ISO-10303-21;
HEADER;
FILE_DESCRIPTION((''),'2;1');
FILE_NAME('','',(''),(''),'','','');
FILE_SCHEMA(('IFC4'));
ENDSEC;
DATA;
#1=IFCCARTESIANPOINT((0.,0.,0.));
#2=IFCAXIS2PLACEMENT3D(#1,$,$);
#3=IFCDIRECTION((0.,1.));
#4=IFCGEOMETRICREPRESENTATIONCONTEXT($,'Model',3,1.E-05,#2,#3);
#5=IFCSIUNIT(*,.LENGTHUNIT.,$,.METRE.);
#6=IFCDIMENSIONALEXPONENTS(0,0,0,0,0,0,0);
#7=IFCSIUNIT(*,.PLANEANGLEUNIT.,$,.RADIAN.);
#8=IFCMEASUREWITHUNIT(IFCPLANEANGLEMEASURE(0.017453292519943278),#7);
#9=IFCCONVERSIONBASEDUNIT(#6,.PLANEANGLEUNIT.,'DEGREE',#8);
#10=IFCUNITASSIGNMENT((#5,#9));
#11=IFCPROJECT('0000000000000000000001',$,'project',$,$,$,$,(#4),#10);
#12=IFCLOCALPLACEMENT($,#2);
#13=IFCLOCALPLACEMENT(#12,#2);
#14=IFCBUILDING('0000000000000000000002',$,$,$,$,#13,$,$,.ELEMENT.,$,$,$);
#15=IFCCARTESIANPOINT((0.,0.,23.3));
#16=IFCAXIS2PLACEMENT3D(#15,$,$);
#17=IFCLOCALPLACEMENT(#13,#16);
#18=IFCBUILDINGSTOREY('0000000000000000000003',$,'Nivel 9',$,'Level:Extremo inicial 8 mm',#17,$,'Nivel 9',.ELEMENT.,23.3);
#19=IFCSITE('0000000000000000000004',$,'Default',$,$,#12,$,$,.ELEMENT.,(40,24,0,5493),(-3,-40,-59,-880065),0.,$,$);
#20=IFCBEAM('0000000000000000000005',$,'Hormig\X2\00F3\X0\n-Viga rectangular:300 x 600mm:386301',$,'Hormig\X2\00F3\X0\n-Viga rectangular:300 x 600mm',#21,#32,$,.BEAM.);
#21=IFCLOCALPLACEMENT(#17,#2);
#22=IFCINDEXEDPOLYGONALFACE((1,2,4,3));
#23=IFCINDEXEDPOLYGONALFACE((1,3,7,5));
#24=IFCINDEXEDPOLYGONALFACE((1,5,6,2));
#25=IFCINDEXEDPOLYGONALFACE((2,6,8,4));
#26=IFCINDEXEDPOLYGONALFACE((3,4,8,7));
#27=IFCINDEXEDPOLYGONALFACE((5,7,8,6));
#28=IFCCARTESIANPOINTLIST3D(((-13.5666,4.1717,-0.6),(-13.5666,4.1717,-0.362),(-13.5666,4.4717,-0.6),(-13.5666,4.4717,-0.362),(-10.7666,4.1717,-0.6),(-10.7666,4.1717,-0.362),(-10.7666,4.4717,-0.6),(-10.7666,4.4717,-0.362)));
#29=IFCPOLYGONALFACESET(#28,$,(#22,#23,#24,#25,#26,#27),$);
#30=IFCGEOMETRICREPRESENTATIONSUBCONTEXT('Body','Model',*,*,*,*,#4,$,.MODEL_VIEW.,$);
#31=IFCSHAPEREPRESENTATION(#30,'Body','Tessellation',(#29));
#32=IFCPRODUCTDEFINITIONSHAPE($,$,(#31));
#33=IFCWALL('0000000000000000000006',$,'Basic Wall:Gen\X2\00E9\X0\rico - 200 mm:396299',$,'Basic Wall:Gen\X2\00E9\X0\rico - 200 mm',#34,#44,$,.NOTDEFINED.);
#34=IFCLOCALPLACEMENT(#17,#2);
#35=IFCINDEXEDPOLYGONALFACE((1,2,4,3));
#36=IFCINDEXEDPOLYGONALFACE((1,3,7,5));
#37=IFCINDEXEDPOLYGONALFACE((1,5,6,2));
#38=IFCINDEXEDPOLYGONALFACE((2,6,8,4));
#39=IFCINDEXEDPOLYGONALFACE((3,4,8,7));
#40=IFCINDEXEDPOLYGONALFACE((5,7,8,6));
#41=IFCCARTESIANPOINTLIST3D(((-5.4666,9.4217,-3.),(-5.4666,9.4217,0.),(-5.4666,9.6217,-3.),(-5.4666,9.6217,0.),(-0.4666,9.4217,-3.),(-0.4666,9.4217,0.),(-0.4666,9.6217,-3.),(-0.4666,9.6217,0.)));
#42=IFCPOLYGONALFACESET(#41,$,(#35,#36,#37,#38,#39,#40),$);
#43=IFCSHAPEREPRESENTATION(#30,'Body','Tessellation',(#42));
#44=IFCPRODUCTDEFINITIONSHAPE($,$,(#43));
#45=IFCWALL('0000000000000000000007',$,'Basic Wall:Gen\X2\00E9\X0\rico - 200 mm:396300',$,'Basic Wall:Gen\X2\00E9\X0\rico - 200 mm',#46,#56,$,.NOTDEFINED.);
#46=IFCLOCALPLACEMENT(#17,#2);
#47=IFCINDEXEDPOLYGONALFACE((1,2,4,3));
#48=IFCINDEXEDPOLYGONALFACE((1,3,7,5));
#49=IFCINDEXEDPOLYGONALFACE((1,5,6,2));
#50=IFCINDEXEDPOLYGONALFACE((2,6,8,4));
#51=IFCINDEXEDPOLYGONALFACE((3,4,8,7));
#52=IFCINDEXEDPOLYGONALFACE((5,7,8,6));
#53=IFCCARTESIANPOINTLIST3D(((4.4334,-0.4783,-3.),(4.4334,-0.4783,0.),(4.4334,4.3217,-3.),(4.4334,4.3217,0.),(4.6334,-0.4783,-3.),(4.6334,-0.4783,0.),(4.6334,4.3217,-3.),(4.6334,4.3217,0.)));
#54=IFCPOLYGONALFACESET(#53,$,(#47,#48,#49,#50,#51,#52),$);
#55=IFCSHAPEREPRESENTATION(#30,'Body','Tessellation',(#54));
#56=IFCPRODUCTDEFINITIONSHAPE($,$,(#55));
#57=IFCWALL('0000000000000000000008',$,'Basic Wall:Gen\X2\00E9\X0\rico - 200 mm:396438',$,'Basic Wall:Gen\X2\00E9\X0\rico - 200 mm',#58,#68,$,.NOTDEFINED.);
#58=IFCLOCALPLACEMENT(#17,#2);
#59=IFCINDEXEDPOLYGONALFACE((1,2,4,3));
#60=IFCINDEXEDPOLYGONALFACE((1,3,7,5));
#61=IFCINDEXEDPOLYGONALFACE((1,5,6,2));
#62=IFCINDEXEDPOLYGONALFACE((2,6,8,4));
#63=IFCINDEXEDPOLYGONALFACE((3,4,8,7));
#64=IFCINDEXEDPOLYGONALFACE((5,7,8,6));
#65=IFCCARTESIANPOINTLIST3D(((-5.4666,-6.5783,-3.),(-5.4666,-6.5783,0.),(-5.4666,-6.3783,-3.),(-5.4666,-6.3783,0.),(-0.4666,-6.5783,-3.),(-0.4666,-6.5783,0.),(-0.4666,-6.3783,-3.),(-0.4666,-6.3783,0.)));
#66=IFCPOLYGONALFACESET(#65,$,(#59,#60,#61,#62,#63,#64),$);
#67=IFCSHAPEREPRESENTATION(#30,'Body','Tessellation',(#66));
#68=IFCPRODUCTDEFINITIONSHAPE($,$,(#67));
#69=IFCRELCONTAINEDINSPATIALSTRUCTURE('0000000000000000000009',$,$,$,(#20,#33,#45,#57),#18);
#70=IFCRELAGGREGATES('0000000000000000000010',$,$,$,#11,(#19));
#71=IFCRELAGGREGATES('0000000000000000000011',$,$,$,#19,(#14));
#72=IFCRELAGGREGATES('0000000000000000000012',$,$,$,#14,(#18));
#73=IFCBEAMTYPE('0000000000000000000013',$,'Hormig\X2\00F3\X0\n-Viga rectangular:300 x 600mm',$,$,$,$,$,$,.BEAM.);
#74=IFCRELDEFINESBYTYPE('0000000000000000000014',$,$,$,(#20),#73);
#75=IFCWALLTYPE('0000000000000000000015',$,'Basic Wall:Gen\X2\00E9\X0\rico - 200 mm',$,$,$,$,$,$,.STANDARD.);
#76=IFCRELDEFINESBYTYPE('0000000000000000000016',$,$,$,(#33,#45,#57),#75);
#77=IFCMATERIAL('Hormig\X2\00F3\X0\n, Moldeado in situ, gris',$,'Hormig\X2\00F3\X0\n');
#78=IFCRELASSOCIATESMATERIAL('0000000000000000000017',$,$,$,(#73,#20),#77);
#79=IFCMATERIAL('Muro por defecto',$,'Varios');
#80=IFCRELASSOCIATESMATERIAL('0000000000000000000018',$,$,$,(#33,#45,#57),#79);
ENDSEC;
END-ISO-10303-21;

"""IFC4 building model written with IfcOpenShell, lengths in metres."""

from ifc_helpers import new_model, entity, si_unit, converted_unit, direction, frame, origin, place, context, subcontext, project, spatial, indexed_curve, outline, extrude, source, transform, mapped, material, type_object, type_shapes, element, save


model = new_model("IFC4")

# Units and contexts
model_context = context("Model", 3, precision=1e-05, world=origin(), true_north=direction((0.0, 1.0)))
body_context = subcontext(model_context, "Body", "Model", "MODEL_VIEW")
ifc_project = project(units=[si_unit("LENGTHUNIT", "METRE"), converted_unit("PLANEANGLEUNIT", "DEGREE", entity("IfcPlaneAngleMeasure", 0.017453292519943278), si_unit("PLANEANGLEUNIT", "RADIAN"), dimensions=[0, 0, 0, 0, 0, 0, 0])], contexts=[model_context])

# Site, building, storey
site_placement = place(None, origin())
site = spatial("IfcSite", under=ifc_project, at=site_placement, Name="Default", CompositionType="ELEMENT", RefLatitude=(40, 24, 0, 5493), RefLongitude=(-3, -40, -59, -880065), RefElevation=0.0)
building_placement = place(site_placement, origin())
building = spatial("IfcBuilding", under=site, at=building_placement, CompositionType="ELEMENT")
storey_placement = place(building_placement, frame((0.0, 0.0, 23.3)))
storey = spatial("IfcBuildingStorey", under=building, at=storey_placement, Name="Nivel 9", ObjectType="Level:Extremo inicial 8 mm", LongName="Nivel 9", CompositionType="ELEMENT", Elevation=23.3)

# Shared definitions
ifc_material_1 = material(Name="Hormigón, Moldeado in situ, gris", Category="Hormigón")

# Beam
beam_type_1 = type_object("IfcBeamType", Name="Hormigón-Viga rectangular:300 x 600mm", PredefinedType="BEAM", material=ifc_material_1)
shared_shape_1 = source(origin(), body_context, "Body", "SweptSolid", [
    extrude(outline(indexed_curve([(-0.119, -0.15), (0.119, -0.15), (0.119, 0.15), (-0.119, 0.15), (-0.119, -0.15)], self_intersect=False)), frame((-10.7666, 4.3217, 22.819), z_axis=(-1.0, 0.0, 0.0), x_axis=(0.0, 0.0, -1.0)), (0.0, 0.0, 1.0), 2.8),
])
type_shapes(beam_type_1, [shared_shape_1])
beam_1_placement = place(storey_placement, frame((0.0, 0.0, -23.3)))
element("IfcBeam", 1, at=beam_1_placement, inside=storey, type_object=beam_type_1, material=ifc_material_1, Name="Hormigón-Viga rectangular:300 x 600mm:386301", ObjectType="Hormigón-Viga rectangular:300 x 600mm", PredefinedType="BEAM", context=body_context, shape_type="MappedRepresentation", body=[
    mapped(shared_shape_1, transform((0.0, 0.0, 0.0), scale=1.0)),
])

# Walls
ifc_material_2 = material(Name="Muro por defecto", Category="Varios")
wall_type = type_object("IfcWallType", Name="Basic Wall:Genérico - 200 mm", PredefinedType="STANDARD")
wall_1_placement = place(storey_placement, frame((-5.4666, 9.5217, -3.0)))
element("IfcWall", 2, at=wall_1_placement, inside=storey, type_object=wall_type, material=ifc_material_2, Name="Basic Wall:Genérico - 200 mm:396299", ObjectType="Basic Wall:Genérico - 200 mm", PredefinedType="NOTDEFINED", context=body_context, shape_type="SweptSolid", body=[
    extrude(outline(indexed_curve([(5.0, 0.1), (0.0, 0.1), (0.0, -0.1), (5.0, -0.1), (5.0, 0.1)], self_intersect=False)), origin(), (0.0, 0.0, 1.0), 3.0),
])
wall_2_placement = place(storey_placement, frame((4.5334, 4.3217, -3.0), z_axis=(0.0, 0.0, 1.0), x_axis=(0.0, -1.0, 0.0)))
element("IfcWall", 3, at=wall_2_placement, inside=storey, type_object=wall_type, material=ifc_material_2, Name="Basic Wall:Genérico - 200 mm:396300", ObjectType="Basic Wall:Genérico - 200 mm", PredefinedType="NOTDEFINED", context=body_context, shape_type="SweptSolid", body=[
    extrude(outline(indexed_curve([(4.8, 0.1), (0.0, 0.1), (0.0, -0.1), (4.8, -0.1), (4.8, 0.1)], self_intersect=False)), origin(), (0.0, 0.0, 1.0), 3.0),
])
wall_3_placement = place(storey_placement, frame((-5.4666, -6.4783, -3.0)))
element("IfcWall", 4, at=wall_3_placement, inside=storey, type_object=wall_type, material=ifc_material_2, Name="Basic Wall:Genérico - 200 mm:396438", ObjectType="Basic Wall:Genérico - 200 mm", PredefinedType="NOTDEFINED", context=body_context, shape_type="SweptSolid", body=[
    extrude(outline(indexed_curve([(5.0, 0.1), (0.0, 0.1), (0.0, -0.1), (5.0, -0.1), (5.0, 0.1)], self_intersect=False)), origin(), (0.0, 0.0, 1.0), 3.0),
])

save(model, "model.ifc")
